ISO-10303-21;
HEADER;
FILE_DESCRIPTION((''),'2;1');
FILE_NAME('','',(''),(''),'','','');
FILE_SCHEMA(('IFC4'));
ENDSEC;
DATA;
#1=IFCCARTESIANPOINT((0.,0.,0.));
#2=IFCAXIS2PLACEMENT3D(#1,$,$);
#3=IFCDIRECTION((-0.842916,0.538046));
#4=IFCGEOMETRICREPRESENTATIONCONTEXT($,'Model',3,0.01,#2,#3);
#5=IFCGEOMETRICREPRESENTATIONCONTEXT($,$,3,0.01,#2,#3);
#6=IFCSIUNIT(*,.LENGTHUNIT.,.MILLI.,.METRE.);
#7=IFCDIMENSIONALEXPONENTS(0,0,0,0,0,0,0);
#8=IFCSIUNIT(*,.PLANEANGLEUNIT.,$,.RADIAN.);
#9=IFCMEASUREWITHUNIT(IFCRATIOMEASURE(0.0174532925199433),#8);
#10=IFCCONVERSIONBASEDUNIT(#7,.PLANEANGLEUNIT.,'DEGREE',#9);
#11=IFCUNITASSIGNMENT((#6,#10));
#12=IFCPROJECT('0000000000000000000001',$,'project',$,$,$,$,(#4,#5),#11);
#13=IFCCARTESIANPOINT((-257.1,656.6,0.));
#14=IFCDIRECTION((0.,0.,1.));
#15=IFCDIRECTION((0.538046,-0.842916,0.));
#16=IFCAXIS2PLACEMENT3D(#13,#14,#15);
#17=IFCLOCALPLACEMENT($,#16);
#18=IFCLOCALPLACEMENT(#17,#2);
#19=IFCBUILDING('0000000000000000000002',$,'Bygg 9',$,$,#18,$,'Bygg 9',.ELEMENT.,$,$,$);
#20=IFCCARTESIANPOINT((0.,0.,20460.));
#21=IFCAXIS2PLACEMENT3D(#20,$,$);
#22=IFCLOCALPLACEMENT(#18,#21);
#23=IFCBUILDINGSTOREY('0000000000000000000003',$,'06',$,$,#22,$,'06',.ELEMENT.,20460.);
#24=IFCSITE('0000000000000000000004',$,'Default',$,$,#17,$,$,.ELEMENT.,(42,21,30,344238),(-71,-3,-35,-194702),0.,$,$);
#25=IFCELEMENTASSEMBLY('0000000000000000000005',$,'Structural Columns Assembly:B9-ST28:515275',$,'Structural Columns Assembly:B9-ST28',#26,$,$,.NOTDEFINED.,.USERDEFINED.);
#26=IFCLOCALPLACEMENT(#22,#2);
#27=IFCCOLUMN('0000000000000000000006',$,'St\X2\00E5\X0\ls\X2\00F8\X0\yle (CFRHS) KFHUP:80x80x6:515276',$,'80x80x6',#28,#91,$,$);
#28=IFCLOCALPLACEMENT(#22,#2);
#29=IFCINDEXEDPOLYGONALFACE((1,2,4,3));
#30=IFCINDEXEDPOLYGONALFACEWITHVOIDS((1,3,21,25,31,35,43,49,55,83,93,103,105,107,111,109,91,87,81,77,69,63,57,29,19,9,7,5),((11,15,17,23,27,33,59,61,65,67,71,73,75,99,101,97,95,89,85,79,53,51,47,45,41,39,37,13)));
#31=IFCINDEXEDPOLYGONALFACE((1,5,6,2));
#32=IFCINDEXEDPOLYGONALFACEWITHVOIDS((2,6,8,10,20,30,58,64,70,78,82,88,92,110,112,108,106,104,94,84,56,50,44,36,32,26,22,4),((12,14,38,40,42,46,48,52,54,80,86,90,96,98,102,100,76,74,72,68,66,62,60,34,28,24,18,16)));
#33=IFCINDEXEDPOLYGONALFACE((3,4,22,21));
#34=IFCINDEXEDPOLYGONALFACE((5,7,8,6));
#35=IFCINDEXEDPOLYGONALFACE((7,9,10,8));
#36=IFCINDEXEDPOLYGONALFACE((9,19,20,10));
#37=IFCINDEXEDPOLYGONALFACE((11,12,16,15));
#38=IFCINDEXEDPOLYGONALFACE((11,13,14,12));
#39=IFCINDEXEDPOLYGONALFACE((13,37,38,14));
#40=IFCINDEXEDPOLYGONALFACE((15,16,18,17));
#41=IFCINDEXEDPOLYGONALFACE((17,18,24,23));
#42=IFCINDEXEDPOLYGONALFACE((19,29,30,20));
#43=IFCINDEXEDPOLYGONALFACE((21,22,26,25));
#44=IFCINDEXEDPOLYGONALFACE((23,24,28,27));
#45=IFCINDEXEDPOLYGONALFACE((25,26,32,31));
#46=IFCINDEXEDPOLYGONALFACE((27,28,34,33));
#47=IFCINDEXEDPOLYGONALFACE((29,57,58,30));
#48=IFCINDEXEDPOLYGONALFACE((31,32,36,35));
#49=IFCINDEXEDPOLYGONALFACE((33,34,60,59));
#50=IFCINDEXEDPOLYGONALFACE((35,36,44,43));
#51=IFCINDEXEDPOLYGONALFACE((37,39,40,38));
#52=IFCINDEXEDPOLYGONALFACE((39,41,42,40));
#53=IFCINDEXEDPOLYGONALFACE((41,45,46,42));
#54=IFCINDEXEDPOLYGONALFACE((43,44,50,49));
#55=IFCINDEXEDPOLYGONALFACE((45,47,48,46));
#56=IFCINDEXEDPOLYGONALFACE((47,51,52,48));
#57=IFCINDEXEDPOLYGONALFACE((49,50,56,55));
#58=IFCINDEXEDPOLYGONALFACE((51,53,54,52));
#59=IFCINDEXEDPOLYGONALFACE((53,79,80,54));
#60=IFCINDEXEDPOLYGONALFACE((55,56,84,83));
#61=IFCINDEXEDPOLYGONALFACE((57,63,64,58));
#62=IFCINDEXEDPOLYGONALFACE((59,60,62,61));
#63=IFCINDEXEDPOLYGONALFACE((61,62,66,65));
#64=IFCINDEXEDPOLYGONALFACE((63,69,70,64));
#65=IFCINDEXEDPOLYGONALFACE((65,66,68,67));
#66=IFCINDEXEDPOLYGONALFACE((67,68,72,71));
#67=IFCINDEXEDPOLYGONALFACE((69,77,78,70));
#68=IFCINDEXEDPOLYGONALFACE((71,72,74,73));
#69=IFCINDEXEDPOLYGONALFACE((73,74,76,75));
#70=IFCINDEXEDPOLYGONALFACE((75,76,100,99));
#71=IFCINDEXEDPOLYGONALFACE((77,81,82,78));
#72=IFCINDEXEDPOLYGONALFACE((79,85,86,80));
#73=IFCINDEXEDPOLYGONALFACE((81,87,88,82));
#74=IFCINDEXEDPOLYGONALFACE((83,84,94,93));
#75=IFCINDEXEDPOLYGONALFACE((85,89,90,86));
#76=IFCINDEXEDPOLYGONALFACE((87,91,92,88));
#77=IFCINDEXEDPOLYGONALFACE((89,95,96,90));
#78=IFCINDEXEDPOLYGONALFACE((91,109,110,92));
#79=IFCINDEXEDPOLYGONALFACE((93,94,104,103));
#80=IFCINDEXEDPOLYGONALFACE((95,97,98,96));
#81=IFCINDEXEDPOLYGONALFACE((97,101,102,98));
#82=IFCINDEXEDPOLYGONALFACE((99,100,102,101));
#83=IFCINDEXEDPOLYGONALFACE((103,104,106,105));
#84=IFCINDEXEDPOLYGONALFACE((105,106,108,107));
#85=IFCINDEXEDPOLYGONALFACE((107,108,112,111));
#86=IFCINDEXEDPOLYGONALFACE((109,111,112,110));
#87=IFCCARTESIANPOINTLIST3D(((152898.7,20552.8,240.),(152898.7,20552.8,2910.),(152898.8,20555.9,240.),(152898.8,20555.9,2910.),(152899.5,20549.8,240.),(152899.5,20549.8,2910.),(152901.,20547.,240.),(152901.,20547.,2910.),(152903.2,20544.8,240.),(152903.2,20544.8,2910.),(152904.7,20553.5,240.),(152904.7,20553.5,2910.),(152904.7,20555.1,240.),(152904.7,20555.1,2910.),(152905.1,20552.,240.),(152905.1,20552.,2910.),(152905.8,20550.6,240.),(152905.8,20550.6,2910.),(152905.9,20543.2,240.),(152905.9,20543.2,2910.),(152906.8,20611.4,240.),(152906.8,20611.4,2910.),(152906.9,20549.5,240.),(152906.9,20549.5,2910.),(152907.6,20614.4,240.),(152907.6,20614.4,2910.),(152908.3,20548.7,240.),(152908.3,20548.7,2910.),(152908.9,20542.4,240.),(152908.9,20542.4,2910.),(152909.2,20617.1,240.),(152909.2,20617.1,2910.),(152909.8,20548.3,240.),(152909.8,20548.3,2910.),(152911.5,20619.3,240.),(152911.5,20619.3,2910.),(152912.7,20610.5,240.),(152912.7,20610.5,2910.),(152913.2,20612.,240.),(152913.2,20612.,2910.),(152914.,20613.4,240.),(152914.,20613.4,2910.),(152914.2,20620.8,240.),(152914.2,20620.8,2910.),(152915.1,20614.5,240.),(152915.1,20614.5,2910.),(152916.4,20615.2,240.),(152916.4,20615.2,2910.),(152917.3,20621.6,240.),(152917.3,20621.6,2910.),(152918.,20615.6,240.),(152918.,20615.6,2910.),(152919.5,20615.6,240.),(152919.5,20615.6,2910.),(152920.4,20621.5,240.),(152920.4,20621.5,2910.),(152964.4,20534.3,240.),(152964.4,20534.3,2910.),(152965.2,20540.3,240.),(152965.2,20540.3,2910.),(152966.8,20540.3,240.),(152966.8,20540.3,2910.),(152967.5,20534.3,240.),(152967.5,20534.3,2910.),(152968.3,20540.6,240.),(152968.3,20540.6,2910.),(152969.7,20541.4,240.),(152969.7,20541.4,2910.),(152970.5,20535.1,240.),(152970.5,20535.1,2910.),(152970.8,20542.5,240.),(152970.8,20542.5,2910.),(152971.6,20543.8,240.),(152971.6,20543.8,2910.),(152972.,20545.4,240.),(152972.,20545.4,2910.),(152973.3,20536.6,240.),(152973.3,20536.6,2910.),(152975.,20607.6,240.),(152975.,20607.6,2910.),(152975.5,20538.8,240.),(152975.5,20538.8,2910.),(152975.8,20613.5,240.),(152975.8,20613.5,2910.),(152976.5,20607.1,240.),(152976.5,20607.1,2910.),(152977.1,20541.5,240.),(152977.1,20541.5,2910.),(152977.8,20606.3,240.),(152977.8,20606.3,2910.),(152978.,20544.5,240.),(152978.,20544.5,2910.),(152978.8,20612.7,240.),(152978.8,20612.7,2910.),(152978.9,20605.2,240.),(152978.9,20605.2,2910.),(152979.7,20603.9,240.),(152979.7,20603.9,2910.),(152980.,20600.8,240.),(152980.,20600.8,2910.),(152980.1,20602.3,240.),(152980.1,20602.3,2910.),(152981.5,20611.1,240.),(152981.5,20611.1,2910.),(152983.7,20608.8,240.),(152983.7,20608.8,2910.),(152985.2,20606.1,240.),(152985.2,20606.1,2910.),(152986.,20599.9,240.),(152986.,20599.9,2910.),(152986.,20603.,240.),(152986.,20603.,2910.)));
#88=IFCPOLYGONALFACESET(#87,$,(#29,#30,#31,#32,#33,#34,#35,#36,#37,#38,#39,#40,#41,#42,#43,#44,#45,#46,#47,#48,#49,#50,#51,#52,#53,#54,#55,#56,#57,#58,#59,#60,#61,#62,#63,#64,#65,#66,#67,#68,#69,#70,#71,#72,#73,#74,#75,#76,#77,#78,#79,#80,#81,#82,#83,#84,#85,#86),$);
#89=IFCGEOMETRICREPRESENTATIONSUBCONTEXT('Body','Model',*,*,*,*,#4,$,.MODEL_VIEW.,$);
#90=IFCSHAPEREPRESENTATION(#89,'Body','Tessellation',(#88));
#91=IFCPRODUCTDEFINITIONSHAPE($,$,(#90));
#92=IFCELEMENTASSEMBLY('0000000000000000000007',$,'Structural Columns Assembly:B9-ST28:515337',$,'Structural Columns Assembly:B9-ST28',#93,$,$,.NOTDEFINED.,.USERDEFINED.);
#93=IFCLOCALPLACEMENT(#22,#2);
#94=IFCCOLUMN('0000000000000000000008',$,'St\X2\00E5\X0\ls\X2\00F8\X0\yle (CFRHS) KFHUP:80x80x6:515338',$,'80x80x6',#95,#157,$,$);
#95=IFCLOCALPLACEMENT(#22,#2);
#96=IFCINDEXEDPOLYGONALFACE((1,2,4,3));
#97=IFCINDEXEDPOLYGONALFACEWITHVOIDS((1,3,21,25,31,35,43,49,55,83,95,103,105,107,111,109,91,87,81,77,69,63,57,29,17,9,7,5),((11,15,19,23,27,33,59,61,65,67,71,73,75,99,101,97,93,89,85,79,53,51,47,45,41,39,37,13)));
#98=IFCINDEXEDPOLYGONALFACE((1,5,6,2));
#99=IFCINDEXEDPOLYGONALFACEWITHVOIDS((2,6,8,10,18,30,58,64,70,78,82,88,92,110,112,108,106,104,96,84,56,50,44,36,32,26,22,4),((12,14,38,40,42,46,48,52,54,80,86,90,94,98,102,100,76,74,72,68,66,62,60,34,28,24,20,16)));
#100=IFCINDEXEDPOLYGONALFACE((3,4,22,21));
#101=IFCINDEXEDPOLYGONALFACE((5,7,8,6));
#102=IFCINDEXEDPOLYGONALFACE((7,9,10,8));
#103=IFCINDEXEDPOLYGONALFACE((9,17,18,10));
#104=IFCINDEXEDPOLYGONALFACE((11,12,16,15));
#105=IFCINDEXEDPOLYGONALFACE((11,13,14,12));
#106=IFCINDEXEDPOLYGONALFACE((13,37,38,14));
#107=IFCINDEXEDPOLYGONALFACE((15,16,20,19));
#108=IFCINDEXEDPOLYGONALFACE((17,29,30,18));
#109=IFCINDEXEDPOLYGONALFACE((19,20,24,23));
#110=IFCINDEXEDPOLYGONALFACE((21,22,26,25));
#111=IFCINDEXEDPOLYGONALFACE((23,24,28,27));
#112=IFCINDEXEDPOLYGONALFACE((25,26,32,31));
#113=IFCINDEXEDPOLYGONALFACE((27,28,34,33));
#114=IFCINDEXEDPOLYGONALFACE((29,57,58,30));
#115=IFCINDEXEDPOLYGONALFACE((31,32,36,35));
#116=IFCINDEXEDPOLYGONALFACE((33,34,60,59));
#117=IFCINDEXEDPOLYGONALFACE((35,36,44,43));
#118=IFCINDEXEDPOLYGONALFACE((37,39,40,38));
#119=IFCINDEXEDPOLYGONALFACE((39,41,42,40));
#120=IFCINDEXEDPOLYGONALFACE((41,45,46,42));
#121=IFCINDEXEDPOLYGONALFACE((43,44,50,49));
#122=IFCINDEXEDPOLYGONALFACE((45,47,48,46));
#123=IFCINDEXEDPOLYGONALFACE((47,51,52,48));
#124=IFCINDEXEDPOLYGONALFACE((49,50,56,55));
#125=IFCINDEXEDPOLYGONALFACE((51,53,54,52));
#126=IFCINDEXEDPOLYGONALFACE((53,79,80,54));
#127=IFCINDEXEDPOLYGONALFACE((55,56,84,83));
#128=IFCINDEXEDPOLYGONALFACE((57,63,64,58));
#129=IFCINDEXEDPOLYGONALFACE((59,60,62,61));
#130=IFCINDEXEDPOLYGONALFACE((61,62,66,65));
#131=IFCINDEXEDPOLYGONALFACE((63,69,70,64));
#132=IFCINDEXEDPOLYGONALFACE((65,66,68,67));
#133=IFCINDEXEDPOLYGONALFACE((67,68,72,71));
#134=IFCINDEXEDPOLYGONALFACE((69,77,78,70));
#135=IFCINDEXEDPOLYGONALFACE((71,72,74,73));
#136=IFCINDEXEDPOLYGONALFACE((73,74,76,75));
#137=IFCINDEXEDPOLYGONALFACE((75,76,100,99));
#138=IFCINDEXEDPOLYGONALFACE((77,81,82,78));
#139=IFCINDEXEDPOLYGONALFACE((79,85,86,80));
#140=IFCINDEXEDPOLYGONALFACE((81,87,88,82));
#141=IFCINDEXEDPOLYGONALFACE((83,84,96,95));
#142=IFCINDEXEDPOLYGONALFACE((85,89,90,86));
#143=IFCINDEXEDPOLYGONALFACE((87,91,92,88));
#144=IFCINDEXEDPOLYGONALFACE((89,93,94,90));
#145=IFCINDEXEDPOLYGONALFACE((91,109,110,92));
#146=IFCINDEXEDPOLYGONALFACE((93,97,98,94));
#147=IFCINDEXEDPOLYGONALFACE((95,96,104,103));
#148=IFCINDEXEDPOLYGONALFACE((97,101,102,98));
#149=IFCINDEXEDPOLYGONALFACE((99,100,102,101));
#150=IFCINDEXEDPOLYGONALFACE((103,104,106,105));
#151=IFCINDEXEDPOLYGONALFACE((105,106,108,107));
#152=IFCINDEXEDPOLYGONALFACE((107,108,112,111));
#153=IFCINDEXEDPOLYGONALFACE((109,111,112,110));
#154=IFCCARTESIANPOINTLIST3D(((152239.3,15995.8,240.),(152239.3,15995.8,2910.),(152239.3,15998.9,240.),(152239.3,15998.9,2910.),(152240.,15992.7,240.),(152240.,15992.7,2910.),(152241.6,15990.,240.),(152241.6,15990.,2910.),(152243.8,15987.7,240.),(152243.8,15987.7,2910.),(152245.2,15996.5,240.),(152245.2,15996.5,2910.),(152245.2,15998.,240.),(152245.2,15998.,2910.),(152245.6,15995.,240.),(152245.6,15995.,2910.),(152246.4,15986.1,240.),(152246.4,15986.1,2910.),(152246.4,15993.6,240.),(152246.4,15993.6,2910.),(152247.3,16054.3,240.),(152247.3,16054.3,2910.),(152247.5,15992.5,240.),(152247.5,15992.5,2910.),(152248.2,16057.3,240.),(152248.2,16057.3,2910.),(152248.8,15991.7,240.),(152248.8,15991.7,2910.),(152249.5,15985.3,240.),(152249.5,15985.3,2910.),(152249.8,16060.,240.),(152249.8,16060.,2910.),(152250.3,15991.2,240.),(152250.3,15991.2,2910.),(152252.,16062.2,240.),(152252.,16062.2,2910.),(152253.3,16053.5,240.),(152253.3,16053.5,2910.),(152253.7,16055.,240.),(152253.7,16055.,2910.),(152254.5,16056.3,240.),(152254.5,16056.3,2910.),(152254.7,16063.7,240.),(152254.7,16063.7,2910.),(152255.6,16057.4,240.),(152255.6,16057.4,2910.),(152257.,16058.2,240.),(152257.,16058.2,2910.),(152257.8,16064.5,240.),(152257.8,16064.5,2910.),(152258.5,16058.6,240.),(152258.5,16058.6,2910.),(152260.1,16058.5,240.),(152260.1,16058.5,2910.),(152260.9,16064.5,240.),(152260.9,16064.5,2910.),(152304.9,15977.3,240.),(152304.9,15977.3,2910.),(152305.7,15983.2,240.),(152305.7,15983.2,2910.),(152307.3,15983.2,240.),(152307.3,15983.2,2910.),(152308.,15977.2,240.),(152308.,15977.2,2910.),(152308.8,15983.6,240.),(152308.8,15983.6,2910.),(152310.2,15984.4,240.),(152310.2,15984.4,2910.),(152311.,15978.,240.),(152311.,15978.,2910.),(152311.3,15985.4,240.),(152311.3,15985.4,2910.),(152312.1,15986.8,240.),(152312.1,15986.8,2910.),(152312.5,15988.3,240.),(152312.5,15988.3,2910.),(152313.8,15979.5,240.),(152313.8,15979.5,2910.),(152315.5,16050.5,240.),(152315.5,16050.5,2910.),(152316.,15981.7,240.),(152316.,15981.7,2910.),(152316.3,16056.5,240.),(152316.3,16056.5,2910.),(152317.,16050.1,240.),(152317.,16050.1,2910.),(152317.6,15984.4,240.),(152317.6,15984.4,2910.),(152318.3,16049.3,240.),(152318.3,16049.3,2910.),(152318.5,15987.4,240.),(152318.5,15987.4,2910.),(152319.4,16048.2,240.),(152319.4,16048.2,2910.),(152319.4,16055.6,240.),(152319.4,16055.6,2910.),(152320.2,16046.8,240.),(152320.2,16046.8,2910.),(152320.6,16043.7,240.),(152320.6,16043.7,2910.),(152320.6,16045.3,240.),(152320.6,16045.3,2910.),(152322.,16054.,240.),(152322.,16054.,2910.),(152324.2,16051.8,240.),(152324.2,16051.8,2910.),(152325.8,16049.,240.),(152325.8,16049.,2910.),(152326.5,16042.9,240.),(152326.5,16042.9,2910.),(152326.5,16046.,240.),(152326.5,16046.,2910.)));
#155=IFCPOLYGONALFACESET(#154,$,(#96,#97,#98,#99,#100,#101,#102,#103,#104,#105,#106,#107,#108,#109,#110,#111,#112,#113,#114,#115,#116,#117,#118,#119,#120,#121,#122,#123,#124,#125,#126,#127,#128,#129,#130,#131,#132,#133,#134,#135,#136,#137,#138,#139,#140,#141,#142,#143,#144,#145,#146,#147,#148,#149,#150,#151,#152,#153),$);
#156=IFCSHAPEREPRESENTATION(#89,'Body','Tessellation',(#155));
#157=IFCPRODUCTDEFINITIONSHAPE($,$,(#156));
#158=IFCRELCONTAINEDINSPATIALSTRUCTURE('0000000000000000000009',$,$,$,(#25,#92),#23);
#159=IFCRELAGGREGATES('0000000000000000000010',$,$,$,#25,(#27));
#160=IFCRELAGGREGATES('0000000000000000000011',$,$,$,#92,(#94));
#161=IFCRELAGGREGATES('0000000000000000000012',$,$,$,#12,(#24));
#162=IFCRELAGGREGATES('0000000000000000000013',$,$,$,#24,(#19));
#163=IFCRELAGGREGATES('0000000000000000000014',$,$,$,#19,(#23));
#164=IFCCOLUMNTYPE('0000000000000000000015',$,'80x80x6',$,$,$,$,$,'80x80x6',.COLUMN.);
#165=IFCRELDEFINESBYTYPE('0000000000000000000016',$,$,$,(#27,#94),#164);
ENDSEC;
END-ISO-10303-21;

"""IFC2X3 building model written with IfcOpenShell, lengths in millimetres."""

from ifc_helpers import new_model, entity, si_unit, converted_unit, direction, frame, frame_2d, origin, place, context, subcontext, project, spatial, polyline, circle_curve, parameter, trimmed, segment, composite_curve, outline, extrude, source, transform, mapped, type_object, type_shapes, element, aggregate, save


model = new_model("IFC2X3")

# Units and contexts
model_context = context("Model", 3, precision=0.01, world=origin(), true_north=direction((-0.842916, 0.538046)))
context_of_model = context(None, 3, precision=0.01, world=origin(), true_north=direction((-0.842916, 0.538046)))
body_context = subcontext(model_context, "Body", "Model", "MODEL_VIEW")
ifc_project = project(units=[si_unit("LENGTHUNIT", "METRE", prefix="MILLI"), converted_unit("PLANEANGLEUNIT", "DEGREE", entity("IfcRatioMeasure", 0.0174532925199433), si_unit("PLANEANGLEUNIT", "RADIAN"), dimensions=[0, 0, 0, 0, 0, 0, 0])], contexts=[model_context, context_of_model])

# Site, building, storey
site_placement = place(None, frame((-257.1, 656.6, 0.0), z_axis=(0.0, 0.0, 1.0), x_axis=(0.538046, -0.842916, 0.0)))
site = spatial("IfcSite", under=ifc_project, at=site_placement, Name="Default", CompositionType="ELEMENT", RefLatitude=(42, 21, 30, 344238), RefLongitude=(-71, -3, -35, -194702), RefElevation=0.0)
building_placement = place(site_placement, origin())
building = spatial("IfcBuilding", under=site, at=building_placement, Name="Bygg 9", LongName="Bygg 9", CompositionType="ELEMENT")
storey_placement = place(building_placement, frame((0.0, 0.0, 20460.0)))
storey = spatial("IfcBuildingStorey", under=building, at=storey_placement, Name="06", LongName="06", CompositionType="ELEMENT", Elevation=20460.0)

# Element assemblies, columns
assembly_1_placement = place(storey_placement, origin())
assembly_1 = element("IfcElementAssembly", 1, at=assembly_1_placement, inside=storey, Name="Structural Columns Assembly:B9-ST28:515275", ObjectType="Structural Columns Assembly:B9-ST28", AssemblyPlace="NOTDEFINED", PredefinedType="USERDEFINED")
column_type = type_object("IfcColumnType", Name="80x80x6", ElementType="80x80x6", PredefinedType="COLUMN")
shared_shape_1 = source(origin(), body_context, "Body", "SweptSolid", [
    extrude(outline(composite_curve([segment(trimmed(circle_curve(frame_2d((-28.0, 28.0), x_axis=(1.0, 0.0)), 12.0), [parameter(90.0)], [parameter(180.0)], True, "PARAMETER"), True, "CONTINUOUS"), segment(polyline([(-40.0, 28.0), (-40.0, -28.0)]), True, "CONTINUOUS"), segment(trimmed(circle_curve(frame_2d((-28.0, -28.0), x_axis=(1.0, 0.0)), 12.0), [parameter(180.0)], [parameter(270.0)], True, "PARAMETER"), True, "CONTINUOUS"), segment(polyline([(-28.0, -40.0), (28.0, -40.0)]), True, "CONTINUOUS"), segment(trimmed(circle_curve(frame_2d((28.0, -28.0), x_axis=(1.0, 0.0)), 12.0), [parameter(270.0)], [parameter(0.0)], True, "PARAMETER"), True, "CONTINUOUS"), segment(polyline([(40.0, -28.0), (40.0, 28.0)]), True, "CONTINUOUS"), segment(trimmed(circle_curve(frame_2d((28.0, 28.0), x_axis=(1.0, 0.0)), 12.0), [parameter(0.0)], [parameter(90.0)], True, "PARAMETER"), True, "CONTINUOUS"), segment(polyline([(28.0, 40.0), (-28.0, 40.0)]), True, "CONTINUOUS")], self_intersect=False), holes=[composite_curve([segment(polyline([(-28.0, 34.0), (28.0, 34.0)]), True, "CONTINUOUS"), segment(trimmed(circle_curve(frame_2d((28.0, 28.0), x_axis=(1.0, 0.0)), 6.0), [parameter(360.0)], [parameter(90.0)], True, "PARAMETER"), False, "CONTINUOUS"), segment(polyline([(34.0, 28.0), (34.0, -28.0)]), True, "CONTINUOUS"), segment(trimmed(circle_curve(frame_2d((28.0, -28.0), x_axis=(1.0, 0.0)), 6.0), [parameter(270.0)], [parameter(360.0)], True, "PARAMETER"), False, "CONTINUOUS"), segment(polyline([(28.0, -34.0), (-28.0, -34.0)]), True, "CONTINUOUS"), segment(trimmed(circle_curve(frame_2d((-28.0, -28.0), x_axis=(1.0, 0.0)), 6.0), [parameter(180.0)], [parameter(270.0)], True, "PARAMETER"), False, "CONTINUOUS"), segment(polyline([(-34.0, -28.0), (-34.0, 28.0)]), True, "CONTINUOUS"), segment(trimmed(circle_curve(frame_2d((-28.0, 28.0), x_axis=(1.0, 0.0)), 6.0), [parameter(90.0)], [parameter(180.0)], True, "PARAMETER"), False, "CONTINUOUS")], self_intersect=False)]), frame((41.6, 41.6, 0.0), z_axis=(0.0, 0.0, 1.0), x_axis=(-1.0, 0.0, 0.0)), (0.0, 0.0, 1.0), 2670.0),
])
type_shapes(column_type, [shared_shape_1])
column_1_placement = place(assembly_1_placement, frame((152989.5, 20613.1, 240.0), z_axis=(0.0, 0.0, 1.0), x_axis=(-0.989694, 0.143198, 0.0)))
column_1 = element("IfcColumn", 2, at=column_1_placement, type_object=column_type, Name="Stålsøyle (CFRHS) KFHUP:80x80x6:515276", ObjectType="80x80x6", context=body_context, shape_type="MappedRepresentation", body=[
    mapped(shared_shape_1, transform((0.0, 0.0, 0.0), scale=1.0)),
])
assembly_2_placement = place(storey_placement, origin())
assembly_2 = element("IfcElementAssembly", 3, at=assembly_2_placement, inside=storey, Name="Structural Columns Assembly:B9-ST28:515337", ObjectType="Structural Columns Assembly:B9-ST28", AssemblyPlace="NOTDEFINED", PredefinedType="USERDEFINED")
column_2_placement = place(assembly_2_placement, frame((152330.0, 16056.1, 240.0), z_axis=(0.0, 0.0, 1.0), x_axis=(-0.989694, 0.143198, 0.0)))
column_2 = element("IfcColumn", 4, at=column_2_placement, type_object=column_type, Name="Stålsøyle (CFRHS) KFHUP:80x80x6:515338", ObjectType="80x80x6", context=body_context, shape_type="MappedRepresentation", body=[
    mapped(shared_shape_1, transform((0.0, 0.0, 0.0), scale=1.0)),
])

aggregate(assembly_1, [column_1])
aggregate(assembly_2, [column_2])

save(model, "model.ifc")
